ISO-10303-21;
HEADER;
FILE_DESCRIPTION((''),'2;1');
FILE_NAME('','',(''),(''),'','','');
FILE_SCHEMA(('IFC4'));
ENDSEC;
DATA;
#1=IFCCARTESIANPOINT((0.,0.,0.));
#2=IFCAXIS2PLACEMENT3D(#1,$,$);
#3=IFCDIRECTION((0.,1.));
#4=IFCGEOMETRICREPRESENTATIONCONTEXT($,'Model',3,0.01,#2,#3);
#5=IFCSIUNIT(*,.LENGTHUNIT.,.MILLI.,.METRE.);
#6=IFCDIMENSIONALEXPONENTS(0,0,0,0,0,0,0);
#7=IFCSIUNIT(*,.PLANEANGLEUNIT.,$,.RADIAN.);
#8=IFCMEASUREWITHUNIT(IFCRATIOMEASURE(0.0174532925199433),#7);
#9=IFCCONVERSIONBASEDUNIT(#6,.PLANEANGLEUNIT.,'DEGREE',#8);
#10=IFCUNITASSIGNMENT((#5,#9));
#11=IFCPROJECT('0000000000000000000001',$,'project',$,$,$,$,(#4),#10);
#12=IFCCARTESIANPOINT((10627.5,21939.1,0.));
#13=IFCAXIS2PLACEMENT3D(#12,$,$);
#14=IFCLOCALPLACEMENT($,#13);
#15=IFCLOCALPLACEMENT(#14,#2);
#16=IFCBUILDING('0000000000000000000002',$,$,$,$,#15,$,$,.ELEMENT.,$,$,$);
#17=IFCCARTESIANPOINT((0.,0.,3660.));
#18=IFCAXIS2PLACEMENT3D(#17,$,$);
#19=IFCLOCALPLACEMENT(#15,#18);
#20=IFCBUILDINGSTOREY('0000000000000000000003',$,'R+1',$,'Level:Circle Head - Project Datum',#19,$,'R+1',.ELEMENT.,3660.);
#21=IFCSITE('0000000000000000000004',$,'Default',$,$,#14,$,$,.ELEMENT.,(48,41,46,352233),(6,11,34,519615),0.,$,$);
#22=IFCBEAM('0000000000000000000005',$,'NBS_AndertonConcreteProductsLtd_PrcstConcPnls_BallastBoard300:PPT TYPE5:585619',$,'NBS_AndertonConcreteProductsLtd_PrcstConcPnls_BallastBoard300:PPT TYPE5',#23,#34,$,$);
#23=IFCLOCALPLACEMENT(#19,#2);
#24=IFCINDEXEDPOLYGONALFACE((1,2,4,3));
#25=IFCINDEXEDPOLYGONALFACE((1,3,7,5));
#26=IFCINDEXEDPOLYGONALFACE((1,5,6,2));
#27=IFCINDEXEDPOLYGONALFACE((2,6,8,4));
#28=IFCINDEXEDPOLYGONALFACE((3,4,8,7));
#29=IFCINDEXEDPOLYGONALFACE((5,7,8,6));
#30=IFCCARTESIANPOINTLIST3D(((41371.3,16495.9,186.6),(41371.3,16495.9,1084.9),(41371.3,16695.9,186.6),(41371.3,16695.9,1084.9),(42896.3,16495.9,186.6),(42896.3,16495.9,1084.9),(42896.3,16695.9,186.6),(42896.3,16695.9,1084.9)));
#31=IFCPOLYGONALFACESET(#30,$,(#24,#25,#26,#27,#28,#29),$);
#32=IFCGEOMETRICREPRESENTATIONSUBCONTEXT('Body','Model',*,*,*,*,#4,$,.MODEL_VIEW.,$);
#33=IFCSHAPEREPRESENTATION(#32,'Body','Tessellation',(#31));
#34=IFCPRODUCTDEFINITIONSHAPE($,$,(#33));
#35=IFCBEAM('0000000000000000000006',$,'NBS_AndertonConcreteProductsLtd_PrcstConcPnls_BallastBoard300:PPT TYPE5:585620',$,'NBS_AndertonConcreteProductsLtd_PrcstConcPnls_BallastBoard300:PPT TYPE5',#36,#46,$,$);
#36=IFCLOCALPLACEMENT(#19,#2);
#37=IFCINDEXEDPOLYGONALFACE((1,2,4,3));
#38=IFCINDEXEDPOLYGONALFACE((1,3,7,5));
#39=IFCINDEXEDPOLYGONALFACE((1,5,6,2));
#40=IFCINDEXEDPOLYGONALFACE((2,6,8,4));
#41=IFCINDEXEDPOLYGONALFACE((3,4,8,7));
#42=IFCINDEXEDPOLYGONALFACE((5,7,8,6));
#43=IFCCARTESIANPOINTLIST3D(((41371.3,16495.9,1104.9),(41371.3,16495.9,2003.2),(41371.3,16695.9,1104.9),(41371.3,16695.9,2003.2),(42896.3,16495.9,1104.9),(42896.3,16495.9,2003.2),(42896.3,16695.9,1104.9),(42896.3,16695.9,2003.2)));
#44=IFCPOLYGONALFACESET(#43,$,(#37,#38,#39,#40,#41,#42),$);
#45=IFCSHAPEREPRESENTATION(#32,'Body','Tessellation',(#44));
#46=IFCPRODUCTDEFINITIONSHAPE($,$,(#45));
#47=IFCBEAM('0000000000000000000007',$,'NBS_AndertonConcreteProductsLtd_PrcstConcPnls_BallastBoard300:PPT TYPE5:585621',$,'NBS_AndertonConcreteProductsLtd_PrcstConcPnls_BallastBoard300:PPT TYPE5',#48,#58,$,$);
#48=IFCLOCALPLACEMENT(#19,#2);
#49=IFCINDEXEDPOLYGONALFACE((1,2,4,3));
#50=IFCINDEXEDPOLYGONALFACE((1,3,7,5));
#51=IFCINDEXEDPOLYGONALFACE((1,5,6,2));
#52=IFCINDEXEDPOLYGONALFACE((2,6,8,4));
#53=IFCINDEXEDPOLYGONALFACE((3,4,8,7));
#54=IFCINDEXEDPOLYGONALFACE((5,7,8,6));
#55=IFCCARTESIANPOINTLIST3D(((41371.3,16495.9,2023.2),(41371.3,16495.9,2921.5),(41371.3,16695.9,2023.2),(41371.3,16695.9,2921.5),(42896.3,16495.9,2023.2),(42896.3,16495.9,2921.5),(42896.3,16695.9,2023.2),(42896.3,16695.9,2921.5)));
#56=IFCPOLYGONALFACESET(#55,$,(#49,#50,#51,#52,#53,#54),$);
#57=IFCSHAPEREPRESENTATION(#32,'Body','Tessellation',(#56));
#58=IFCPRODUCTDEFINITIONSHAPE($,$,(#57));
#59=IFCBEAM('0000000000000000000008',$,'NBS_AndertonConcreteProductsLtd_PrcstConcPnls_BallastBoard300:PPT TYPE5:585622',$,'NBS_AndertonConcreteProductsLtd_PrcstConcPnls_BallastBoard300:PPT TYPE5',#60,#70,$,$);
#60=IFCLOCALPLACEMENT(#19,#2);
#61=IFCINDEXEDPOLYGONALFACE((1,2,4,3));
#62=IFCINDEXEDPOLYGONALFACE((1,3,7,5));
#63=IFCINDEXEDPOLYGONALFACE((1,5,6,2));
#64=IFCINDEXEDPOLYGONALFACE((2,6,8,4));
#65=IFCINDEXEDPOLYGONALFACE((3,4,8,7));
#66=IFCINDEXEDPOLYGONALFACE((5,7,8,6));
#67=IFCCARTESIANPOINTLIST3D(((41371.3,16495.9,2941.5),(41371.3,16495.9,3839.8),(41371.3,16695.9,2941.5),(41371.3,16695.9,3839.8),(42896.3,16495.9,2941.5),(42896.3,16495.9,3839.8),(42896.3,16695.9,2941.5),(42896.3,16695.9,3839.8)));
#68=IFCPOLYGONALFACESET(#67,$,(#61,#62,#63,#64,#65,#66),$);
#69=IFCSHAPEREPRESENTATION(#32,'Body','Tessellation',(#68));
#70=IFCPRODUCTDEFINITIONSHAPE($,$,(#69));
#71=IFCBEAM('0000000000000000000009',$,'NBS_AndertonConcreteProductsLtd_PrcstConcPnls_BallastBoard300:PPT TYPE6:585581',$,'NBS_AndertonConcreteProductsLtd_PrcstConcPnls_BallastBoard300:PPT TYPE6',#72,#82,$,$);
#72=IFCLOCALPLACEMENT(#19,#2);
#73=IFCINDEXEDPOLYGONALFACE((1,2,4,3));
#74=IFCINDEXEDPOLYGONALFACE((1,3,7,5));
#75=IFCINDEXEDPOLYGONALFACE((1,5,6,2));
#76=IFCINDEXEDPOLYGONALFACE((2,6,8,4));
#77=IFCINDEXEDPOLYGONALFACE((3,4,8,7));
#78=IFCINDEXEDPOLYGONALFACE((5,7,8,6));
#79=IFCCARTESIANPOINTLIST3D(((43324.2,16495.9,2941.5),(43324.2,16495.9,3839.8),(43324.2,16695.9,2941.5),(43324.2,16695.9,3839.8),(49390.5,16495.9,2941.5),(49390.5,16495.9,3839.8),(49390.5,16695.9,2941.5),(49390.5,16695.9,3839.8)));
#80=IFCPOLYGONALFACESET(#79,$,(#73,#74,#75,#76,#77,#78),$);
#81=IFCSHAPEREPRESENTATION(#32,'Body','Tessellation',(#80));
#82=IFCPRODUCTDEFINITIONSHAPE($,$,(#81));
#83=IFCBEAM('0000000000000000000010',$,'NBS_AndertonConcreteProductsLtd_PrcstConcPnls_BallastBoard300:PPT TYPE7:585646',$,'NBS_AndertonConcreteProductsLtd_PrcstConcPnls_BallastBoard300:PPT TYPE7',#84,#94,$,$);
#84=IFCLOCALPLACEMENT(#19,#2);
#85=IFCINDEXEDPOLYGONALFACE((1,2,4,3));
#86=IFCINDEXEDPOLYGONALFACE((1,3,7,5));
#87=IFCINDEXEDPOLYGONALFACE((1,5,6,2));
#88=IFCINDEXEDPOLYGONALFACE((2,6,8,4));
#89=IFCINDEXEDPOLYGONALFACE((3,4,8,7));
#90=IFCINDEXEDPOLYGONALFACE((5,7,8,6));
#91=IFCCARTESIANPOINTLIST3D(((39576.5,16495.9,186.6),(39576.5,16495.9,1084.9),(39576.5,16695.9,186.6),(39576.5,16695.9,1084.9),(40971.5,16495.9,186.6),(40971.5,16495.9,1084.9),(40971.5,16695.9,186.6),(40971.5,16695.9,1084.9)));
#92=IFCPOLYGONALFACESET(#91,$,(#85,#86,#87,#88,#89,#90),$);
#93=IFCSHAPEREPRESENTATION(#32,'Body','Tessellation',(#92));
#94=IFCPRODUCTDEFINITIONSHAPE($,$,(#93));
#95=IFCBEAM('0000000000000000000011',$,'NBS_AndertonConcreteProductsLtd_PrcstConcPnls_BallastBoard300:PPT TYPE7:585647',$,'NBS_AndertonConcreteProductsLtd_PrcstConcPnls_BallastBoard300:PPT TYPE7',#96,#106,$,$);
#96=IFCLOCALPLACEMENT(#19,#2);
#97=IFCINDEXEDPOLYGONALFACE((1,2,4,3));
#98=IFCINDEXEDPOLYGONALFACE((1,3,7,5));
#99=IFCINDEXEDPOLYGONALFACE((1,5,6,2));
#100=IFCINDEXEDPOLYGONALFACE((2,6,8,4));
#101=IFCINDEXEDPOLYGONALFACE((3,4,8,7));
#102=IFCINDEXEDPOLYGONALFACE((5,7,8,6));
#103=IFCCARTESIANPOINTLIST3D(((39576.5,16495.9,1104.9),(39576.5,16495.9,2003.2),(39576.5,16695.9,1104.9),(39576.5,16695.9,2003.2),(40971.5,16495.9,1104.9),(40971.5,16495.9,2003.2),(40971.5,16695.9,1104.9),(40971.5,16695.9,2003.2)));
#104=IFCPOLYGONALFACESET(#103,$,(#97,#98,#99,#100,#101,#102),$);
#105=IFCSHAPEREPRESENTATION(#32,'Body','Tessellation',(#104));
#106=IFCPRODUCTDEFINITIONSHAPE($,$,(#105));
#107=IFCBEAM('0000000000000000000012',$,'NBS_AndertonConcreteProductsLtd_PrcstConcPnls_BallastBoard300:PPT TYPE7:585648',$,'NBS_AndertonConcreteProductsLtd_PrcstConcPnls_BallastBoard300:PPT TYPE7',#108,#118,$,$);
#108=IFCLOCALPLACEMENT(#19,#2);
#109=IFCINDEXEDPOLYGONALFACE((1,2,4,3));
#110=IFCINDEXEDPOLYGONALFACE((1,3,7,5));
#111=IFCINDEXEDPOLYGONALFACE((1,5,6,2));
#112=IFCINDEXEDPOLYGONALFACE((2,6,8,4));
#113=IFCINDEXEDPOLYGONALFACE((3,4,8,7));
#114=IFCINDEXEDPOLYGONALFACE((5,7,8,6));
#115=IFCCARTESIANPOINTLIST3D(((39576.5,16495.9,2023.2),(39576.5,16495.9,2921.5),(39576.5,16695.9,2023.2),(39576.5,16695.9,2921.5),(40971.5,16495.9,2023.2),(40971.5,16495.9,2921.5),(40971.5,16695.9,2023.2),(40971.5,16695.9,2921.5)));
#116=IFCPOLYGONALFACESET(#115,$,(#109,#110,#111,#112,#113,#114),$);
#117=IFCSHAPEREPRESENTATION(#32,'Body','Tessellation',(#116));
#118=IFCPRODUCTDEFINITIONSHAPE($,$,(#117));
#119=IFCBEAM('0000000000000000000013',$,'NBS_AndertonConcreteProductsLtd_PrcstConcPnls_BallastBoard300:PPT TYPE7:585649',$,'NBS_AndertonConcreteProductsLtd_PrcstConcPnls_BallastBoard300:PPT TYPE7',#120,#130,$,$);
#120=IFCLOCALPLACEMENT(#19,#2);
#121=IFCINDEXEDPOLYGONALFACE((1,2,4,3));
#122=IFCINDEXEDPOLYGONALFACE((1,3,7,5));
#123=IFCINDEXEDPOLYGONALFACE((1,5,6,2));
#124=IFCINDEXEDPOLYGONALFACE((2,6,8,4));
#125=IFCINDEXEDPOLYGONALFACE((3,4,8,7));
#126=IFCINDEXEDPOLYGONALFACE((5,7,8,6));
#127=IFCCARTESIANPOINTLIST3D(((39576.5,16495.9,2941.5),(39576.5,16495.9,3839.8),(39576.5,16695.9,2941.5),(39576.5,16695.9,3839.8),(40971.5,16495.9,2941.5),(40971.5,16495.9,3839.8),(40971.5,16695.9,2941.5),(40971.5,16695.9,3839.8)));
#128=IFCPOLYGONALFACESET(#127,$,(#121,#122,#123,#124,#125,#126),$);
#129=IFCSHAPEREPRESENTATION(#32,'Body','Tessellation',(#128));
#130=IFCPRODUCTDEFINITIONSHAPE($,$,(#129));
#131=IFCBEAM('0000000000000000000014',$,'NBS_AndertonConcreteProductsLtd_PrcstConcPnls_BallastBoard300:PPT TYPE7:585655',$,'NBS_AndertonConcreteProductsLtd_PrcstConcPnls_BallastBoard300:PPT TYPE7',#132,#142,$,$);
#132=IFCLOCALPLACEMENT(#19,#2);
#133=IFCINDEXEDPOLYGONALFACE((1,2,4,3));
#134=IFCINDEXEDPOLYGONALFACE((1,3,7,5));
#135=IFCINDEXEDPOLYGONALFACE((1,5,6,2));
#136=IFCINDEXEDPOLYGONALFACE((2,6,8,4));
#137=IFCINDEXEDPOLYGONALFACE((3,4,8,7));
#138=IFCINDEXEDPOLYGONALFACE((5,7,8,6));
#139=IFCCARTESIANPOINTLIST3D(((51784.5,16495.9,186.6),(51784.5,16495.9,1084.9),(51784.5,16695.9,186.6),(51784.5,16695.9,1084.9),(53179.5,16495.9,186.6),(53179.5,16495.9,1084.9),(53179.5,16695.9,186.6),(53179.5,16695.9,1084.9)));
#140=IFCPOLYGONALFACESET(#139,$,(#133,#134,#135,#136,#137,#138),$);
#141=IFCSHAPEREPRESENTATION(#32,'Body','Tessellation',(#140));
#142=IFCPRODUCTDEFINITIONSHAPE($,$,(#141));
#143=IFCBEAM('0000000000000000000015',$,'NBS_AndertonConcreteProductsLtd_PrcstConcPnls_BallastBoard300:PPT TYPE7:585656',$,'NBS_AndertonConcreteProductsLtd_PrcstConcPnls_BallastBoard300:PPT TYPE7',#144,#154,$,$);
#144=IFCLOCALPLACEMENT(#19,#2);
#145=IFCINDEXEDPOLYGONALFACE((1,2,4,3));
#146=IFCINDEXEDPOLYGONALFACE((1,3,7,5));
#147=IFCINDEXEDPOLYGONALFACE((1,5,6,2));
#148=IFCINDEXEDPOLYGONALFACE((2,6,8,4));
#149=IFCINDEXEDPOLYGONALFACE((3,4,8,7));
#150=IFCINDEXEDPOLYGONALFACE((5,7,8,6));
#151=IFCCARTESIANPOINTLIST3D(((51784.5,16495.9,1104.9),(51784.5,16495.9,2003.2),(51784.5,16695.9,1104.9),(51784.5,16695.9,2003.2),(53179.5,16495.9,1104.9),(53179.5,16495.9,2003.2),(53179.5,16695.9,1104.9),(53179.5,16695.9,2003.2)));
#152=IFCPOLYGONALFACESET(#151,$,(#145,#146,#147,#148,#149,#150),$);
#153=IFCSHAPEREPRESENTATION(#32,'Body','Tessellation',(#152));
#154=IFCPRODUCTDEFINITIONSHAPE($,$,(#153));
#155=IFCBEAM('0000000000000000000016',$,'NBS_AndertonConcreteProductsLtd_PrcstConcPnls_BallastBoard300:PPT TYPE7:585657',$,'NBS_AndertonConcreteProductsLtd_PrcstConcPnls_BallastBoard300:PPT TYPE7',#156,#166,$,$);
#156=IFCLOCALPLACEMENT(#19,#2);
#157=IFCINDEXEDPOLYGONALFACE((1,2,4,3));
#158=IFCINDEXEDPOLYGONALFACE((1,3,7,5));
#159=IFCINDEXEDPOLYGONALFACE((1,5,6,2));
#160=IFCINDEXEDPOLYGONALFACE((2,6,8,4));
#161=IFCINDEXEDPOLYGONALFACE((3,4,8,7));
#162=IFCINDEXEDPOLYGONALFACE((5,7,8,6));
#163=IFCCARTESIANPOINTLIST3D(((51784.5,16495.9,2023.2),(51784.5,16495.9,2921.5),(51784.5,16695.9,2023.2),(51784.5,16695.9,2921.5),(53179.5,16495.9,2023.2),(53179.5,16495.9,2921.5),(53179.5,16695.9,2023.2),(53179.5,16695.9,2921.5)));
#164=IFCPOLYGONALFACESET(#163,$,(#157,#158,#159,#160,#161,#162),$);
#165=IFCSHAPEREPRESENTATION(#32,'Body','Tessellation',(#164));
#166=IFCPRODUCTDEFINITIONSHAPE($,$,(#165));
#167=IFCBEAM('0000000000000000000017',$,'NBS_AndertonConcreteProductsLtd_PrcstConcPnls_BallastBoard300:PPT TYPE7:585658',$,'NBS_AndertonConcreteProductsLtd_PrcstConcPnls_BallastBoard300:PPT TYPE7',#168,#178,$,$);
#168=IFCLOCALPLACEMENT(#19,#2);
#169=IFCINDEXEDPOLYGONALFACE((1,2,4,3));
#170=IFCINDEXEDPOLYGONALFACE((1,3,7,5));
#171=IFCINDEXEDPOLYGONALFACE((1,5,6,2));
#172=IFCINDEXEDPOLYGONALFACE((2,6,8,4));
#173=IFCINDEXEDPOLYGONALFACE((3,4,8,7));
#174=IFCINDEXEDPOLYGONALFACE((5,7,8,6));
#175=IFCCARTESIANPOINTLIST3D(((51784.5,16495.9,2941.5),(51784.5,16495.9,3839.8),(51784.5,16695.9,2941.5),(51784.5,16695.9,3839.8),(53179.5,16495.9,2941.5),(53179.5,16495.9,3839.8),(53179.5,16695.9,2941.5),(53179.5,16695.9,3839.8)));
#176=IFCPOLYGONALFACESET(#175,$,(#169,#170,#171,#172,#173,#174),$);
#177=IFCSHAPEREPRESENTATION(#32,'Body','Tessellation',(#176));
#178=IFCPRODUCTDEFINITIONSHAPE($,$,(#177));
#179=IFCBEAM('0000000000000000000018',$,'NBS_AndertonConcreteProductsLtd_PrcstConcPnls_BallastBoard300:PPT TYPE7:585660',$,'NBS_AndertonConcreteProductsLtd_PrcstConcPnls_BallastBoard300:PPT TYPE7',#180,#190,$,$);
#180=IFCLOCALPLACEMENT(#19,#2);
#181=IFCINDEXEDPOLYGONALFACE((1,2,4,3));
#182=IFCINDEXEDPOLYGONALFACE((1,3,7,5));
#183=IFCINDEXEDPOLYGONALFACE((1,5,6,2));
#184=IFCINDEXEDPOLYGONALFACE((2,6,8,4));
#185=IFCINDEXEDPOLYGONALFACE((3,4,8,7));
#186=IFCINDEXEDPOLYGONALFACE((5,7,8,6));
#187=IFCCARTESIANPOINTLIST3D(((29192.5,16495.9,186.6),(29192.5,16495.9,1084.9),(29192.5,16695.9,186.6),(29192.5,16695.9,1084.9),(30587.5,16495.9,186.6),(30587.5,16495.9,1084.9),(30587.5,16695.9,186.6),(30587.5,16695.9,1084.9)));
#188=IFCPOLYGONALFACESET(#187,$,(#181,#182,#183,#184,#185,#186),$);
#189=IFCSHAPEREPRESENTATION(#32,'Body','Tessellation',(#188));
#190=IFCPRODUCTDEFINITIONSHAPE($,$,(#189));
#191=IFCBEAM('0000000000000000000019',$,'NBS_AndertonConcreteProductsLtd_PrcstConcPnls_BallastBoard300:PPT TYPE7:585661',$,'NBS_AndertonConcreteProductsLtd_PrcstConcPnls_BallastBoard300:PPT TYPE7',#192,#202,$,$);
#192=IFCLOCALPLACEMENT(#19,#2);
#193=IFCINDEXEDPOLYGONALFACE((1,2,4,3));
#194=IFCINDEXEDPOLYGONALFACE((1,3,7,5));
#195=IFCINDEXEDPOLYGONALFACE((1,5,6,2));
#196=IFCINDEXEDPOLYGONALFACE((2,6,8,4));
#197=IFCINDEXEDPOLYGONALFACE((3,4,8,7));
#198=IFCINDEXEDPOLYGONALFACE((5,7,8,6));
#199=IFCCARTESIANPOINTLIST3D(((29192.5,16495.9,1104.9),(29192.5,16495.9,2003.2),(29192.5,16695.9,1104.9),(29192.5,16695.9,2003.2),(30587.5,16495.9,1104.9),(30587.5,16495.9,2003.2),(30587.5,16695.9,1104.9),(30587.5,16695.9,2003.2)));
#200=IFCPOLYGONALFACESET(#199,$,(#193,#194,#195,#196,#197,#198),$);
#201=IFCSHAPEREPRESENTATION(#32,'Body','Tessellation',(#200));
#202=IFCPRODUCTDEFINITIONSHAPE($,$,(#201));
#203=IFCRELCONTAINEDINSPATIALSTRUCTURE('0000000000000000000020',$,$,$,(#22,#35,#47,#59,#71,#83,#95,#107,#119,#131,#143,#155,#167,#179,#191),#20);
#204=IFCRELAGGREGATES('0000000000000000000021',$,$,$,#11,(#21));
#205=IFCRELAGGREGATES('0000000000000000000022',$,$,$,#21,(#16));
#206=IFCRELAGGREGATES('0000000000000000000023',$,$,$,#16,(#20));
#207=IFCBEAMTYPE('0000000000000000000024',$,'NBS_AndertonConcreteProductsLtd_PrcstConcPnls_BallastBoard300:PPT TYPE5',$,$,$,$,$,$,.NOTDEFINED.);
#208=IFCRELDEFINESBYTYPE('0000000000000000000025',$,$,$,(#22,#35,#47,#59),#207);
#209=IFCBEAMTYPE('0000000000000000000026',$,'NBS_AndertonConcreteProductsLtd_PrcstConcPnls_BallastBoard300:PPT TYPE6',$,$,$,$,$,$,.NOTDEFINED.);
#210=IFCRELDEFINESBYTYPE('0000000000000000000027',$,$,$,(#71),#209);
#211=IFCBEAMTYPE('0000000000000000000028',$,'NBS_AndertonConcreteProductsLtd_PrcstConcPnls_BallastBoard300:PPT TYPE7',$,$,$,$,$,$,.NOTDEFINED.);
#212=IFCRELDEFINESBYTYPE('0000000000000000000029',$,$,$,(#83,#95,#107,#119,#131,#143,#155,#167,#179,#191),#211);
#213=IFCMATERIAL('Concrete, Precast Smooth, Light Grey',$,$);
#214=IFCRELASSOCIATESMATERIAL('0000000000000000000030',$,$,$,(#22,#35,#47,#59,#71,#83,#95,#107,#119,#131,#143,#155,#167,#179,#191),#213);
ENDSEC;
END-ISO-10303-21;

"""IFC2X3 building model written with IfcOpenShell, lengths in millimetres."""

from ifc_helpers import new_model, entity, si_unit, converted_unit, direction, frame, frame_2d, origin, place, context, subcontext, project, spatial, rectangle, extrude, material, type_object, element, save


model = new_model("IFC2X3")

# Units and contexts
model_context = context("Model", 3, precision=0.01, world=origin(), true_north=direction((0.0, 1.0)))
body_context = subcontext(model_context, "Body", "Model", "MODEL_VIEW")
ifc_project = project(units=[si_unit("LENGTHUNIT", "METRE", prefix="MILLI"), converted_unit("PLANEANGLEUNIT", "DEGREE", entity("IfcRatioMeasure", 0.0174532925199433), si_unit("PLANEANGLEUNIT", "RADIAN"), dimensions=[0, 0, 0, 0, 0, 0, 0])], contexts=[model_context])

# Site, building, storey
site_placement = place(None, frame((10627.5, 21939.1, 0.0)))
site = spatial("IfcSite", under=ifc_project, at=site_placement, Name="Default", CompositionType="ELEMENT", RefLatitude=(48, 41, 46, 352233), RefLongitude=(6, 11, 34, 519615), RefElevation=0.0)
building_placement = place(site_placement, origin())
building = spatial("IfcBuilding", under=site, at=building_placement, CompositionType="ELEMENT")
storey_placement = place(building_placement, frame((0.0, 0.0, 3660.0)))
storey = spatial("IfcBuildingStorey", under=building, at=storey_placement, Name="R+1", ObjectType="Level:Circle Head - Project Datum", LongName="R+1", CompositionType="ELEMENT", Elevation=3660.0)

# Shared definitions
ifc_material_1 = material(Name="Concrete, Precast Smooth, Light Grey")

# Beams
beam_type_1 = type_object("IfcBeamType", Name="NBS_AndertonConcreteProductsLtd_PrcstConcPnls_BallastBoard300:PPT TYPE5", PredefinedType="NOTDEFINED")
beam_1_placement = place(storey_placement, origin())
element("IfcBeam", 1, at=beam_1_placement, inside=storey, type_object=beam_type_1, material=ifc_material_1, Name="NBS_AndertonConcreteProductsLtd_PrcstConcPnls_BallastBoard300:PPT TYPE5:585619", ObjectType="NBS_AndertonConcreteProductsLtd_PrcstConcPnls_BallastBoard300:PPT TYPE5", context=body_context, shape_type="SweptSolid", body=[
    extrude(rectangle(XDim=898.3, YDim=200.0, at=frame_2d((0.0, 0.0), x_axis=(1.0, 0.0))), frame((41371.3, 16595.9, 635.8), z_axis=(1.0, 0.0, 0.0), x_axis=(0.0, 0.0, -1.0)), (0.0, 0.0, 1.0), 1525.0),
])
beam_2_placement = place(storey_placement, origin())
element("IfcBeam", 2, at=beam_2_placement, inside=storey, type_object=beam_type_1, material=ifc_material_1, Name="NBS_AndertonConcreteProductsLtd_PrcstConcPnls_BallastBoard300:PPT TYPE5:585620", ObjectType="NBS_AndertonConcreteProductsLtd_PrcstConcPnls_BallastBoard300:PPT TYPE5", context=body_context, shape_type="SweptSolid", body=[
    extrude(rectangle(XDim=898.3, YDim=200.0, at=frame_2d((0.0, 0.0), x_axis=(1.0, 0.0))), frame((41371.3, 16595.9, 1554.1), z_axis=(1.0, 0.0, 0.0), x_axis=(0.0, 0.0, -1.0)), (0.0, 0.0, 1.0), 1525.0),
])
beam_3_placement = place(storey_placement, origin())
element("IfcBeam", 3, at=beam_3_placement, inside=storey, type_object=beam_type_1, material=ifc_material_1, Name="NBS_AndertonConcreteProductsLtd_PrcstConcPnls_BallastBoard300:PPT TYPE5:585621", ObjectType="NBS_AndertonConcreteProductsLtd_PrcstConcPnls_BallastBoard300:PPT TYPE5", context=body_context, shape_type="SweptSolid", body=[
    extrude(rectangle(XDim=898.3, YDim=200.0, at=frame_2d((0.0, 0.0), x_axis=(1.0, 0.0))), frame((41371.3, 16595.9, 2472.4), z_axis=(1.0, 0.0, 0.0), x_axis=(0.0, 0.0, -1.0)), (0.0, 0.0, 1.0), 1525.0),
])
beam_4_placement = place(storey_placement, origin())
element("IfcBeam", 4, at=beam_4_placement, inside=storey, type_object=beam_type_1, material=ifc_material_1, Name="NBS_AndertonConcreteProductsLtd_PrcstConcPnls_BallastBoard300:PPT TYPE5:585622", ObjectType="NBS_AndertonConcreteProductsLtd_PrcstConcPnls_BallastBoard300:PPT TYPE5", context=body_context, shape_type="SweptSolid", body=[
    extrude(rectangle(XDim=898.3, YDim=200.0, at=frame_2d((0.0, 0.0), x_axis=(1.0, 0.0))), frame((41371.3, 16595.9, 3390.7), z_axis=(1.0, 0.0, 0.0), x_axis=(0.0, 0.0, -1.0)), (0.0, 0.0, 1.0), 1525.0),
])
beam_type_2 = type_object("IfcBeamType", Name="NBS_AndertonConcreteProductsLtd_PrcstConcPnls_BallastBoard300:PPT TYPE6", PredefinedType="NOTDEFINED")
beam_5_placement = place(storey_placement, origin())
element("IfcBeam", 5, at=beam_5_placement, inside=storey, type_object=beam_type_2, material=ifc_material_1, Name="NBS_AndertonConcreteProductsLtd_PrcstConcPnls_BallastBoard300:PPT TYPE6:585581", ObjectType="NBS_AndertonConcreteProductsLtd_PrcstConcPnls_BallastBoard300:PPT TYPE6", context=body_context, shape_type="SweptSolid", body=[
    extrude(rectangle(XDim=898.3, YDim=200.0, at=frame_2d((0.0, 0.0), x_axis=(1.0, 0.0))), frame((43324.2, 16595.9, 3390.7), z_axis=(1.0, 0.0, 0.0), x_axis=(0.0, 0.0, -1.0)), (0.0, 0.0, 1.0), 6066.3),
])
beam_type_3 = type_object("IfcBeamType", Name="NBS_AndertonConcreteProductsLtd_PrcstConcPnls_BallastBoard300:PPT TYPE7", PredefinedType="NOTDEFINED")
beam_6_placement = place(storey_placement, origin())
element("IfcBeam", 6, at=beam_6_placement, inside=storey, type_object=beam_type_3, material=ifc_material_1, Name="NBS_AndertonConcreteProductsLtd_PrcstConcPnls_BallastBoard300:PPT TYPE7:585646", ObjectType="NBS_AndertonConcreteProductsLtd_PrcstConcPnls_BallastBoard300:PPT TYPE7", context=body_context, shape_type="SweptSolid", body=[
    extrude(rectangle(XDim=898.3, YDim=200.0, at=frame_2d((0.0, 0.0), x_axis=(1.0, 0.0))), frame((39576.5, 16595.9, 635.8), z_axis=(1.0, 0.0, 0.0), x_axis=(0.0, 0.0, -1.0)), (0.0, 0.0, 1.0), 1395.0),
])
beam_7_placement = place(storey_placement, origin())
element("IfcBeam", 7, at=beam_7_placement, inside=storey, type_object=beam_type_3, material=ifc_material_1, Name="NBS_AndertonConcreteProductsLtd_PrcstConcPnls_BallastBoard300:PPT TYPE7:585647", ObjectType="NBS_AndertonConcreteProductsLtd_PrcstConcPnls_BallastBoard300:PPT TYPE7", context=body_context, shape_type="SweptSolid", body=[
    extrude(rectangle(XDim=898.3, YDim=200.0, at=frame_2d((0.0, 0.0), x_axis=(1.0, 0.0))), frame((39576.5, 16595.9, 1554.1), z_axis=(1.0, 0.0, 0.0), x_axis=(0.0, 0.0, -1.0)), (0.0, 0.0, 1.0), 1395.0),
])
beam_8_placement = place(storey_placement, origin())
element("IfcBeam", 8, at=beam_8_placement, inside=storey, type_object=beam_type_3, material=ifc_material_1, Name="NBS_AndertonConcreteProductsLtd_PrcstConcPnls_BallastBoard300:PPT TYPE7:585648", ObjectType="NBS_AndertonConcreteProductsLtd_PrcstConcPnls_BallastBoard300:PPT TYPE7", context=body_context, shape_type="SweptSolid", body=[
    extrude(rectangle(XDim=898.3, YDim=200.0, at=frame_2d((0.0, 0.0), x_axis=(1.0, 0.0))), frame((39576.5, 16595.9, 2472.4), z_axis=(1.0, 0.0, 0.0), x_axis=(0.0, 0.0, -1.0)), (0.0, 0.0, 1.0), 1395.0),
])
beam_9_placement = place(storey_placement, origin())
element("IfcBeam", 9, at=beam_9_placement, inside=storey, type_object=beam_type_3, material=ifc_material_1, Name="NBS_AndertonConcreteProductsLtd_PrcstConcPnls_BallastBoard300:PPT TYPE7:585649", ObjectType="NBS_AndertonConcreteProductsLtd_PrcstConcPnls_BallastBoard300:PPT TYPE7", context=body_context, shape_type="SweptSolid", body=[
    extrude(rectangle(XDim=898.3, YDim=200.0, at=frame_2d((0.0, 0.0), x_axis=(1.0, 0.0))), frame((39576.5, 16595.9, 3390.7), z_axis=(1.0, 0.0, 0.0), x_axis=(0.0, 0.0, -1.0)), (0.0, 0.0, 1.0), 1395.0),
])
beam_10_placement = place(storey_placement, origin())
element("IfcBeam", 10, at=beam_10_placement, inside=storey, type_object=beam_type_3, material=ifc_material_1, Name="NBS_AndertonConcreteProductsLtd_PrcstConcPnls_BallastBoard300:PPT TYPE7:585655", ObjectType="NBS_AndertonConcreteProductsLtd_PrcstConcPnls_BallastBoard300:PPT TYPE7", context=body_context, shape_type="SweptSolid", body=[
    extrude(rectangle(XDim=898.3, YDim=200.0, at=frame_2d((0.0, 0.0), x_axis=(1.0, 0.0))), frame((51784.5, 16595.9, 635.8), z_axis=(1.0, 0.0, 0.0), x_axis=(0.0, 0.0, -1.0)), (0.0, 0.0, 1.0), 1395.0),
])
beam_11_placement = place(storey_placement, origin())
element("IfcBeam", 11, at=beam_11_placement, inside=storey, type_object=beam_type_3, material=ifc_material_1, Name="NBS_AndertonConcreteProductsLtd_PrcstConcPnls_BallastBoard300:PPT TYPE7:585656", ObjectType="NBS_AndertonConcreteProductsLtd_PrcstConcPnls_BallastBoard300:PPT TYPE7", context=body_context, shape_type="SweptSolid", body=[
    extrude(rectangle(XDim=898.3, YDim=200.0, at=frame_2d((0.0, 0.0), x_axis=(1.0, 0.0))), frame((51784.5, 16595.9, 1554.1), z_axis=(1.0, 0.0, 0.0), x_axis=(0.0, 0.0, -1.0)), (0.0, 0.0, 1.0), 1395.0),
])
beam_12_placement = place(storey_placement, origin())
element("IfcBeam", 12, at=beam_12_placement, inside=storey, type_object=beam_type_3, material=ifc_material_1, Name="NBS_AndertonConcreteProductsLtd_PrcstConcPnls_BallastBoard300:PPT TYPE7:585657", ObjectType="NBS_AndertonConcreteProductsLtd_PrcstConcPnls_BallastBoard300:PPT TYPE7", context=body_context, shape_type="SweptSolid", body=[
    extrude(rectangle(XDim=898.3, YDim=200.0, at=frame_2d((0.0, 0.0), x_axis=(1.0, 0.0))), frame((51784.5, 16595.9, 2472.4), z_axis=(1.0, 0.0, 0.0), x_axis=(0.0, 0.0, -1.0)), (0.0, 0.0, 1.0), 1395.0),
])
beam_13_placement = place(storey_placement, origin())
element("IfcBeam", 13, at=beam_13_placement, inside=storey, type_object=beam_type_3, material=ifc_material_1, Name="NBS_AndertonConcreteProductsLtd_PrcstConcPnls_BallastBoard300:PPT TYPE7:585658", ObjectType="NBS_AndertonConcreteProductsLtd_PrcstConcPnls_BallastBoard300:PPT TYPE7", context=body_context, shape_type="SweptSolid", body=[
    extrude(rectangle(XDim=898.3, YDim=200.0, at=frame_2d((0.0, 0.0), x_axis=(1.0, 0.0))), frame((51784.5, 16595.9, 3390.7), z_axis=(1.0, 0.0, 0.0), x_axis=(0.0, 0.0, -1.0)), (0.0, 0.0, 1.0), 1395.0),
])
beam_14_placement = place(storey_placement, origin())
element("IfcBeam", 14, at=beam_14_placement, inside=storey, type_object=beam_type_3, material=ifc_material_1, Name="NBS_AndertonConcreteProductsLtd_PrcstConcPnls_BallastBoard300:PPT TYPE7:585660", ObjectType="NBS_AndertonConcreteProductsLtd_PrcstConcPnls_BallastBoard300:PPT TYPE7", context=body_context, shape_type="SweptSolid", body=[
    extrude(rectangle(XDim=898.3, YDim=200.0, at=frame_2d((0.0, 0.0), x_axis=(1.0, 0.0))), frame((29192.5, 16595.9, 635.8), z_axis=(1.0, 0.0, 0.0), x_axis=(0.0, 0.0, -1.0)), (0.0, 0.0, 1.0), 1395.0),
])
beam_15_placement = place(storey_placement, origin())
element("IfcBeam", 15, at=beam_15_placement, inside=storey, type_object=beam_type_3, material=ifc_material_1, Name="NBS_AndertonConcreteProductsLtd_PrcstConcPnls_BallastBoard300:PPT TYPE7:585661", ObjectType="NBS_AndertonConcreteProductsLtd_PrcstConcPnls_BallastBoard300:PPT TYPE7", context=body_context, shape_type="SweptSolid", body=[
    extrude(rectangle(XDim=898.3, YDim=200.0, at=frame_2d((0.0, 0.0), x_axis=(1.0, 0.0))), frame((29192.5, 16595.9, 1554.1), z_axis=(1.0, 0.0, 0.0), x_axis=(0.0, 0.0, -1.0)), (0.0, 0.0, 1.0), 1395.0),
])

save(model, "model.ifc")
